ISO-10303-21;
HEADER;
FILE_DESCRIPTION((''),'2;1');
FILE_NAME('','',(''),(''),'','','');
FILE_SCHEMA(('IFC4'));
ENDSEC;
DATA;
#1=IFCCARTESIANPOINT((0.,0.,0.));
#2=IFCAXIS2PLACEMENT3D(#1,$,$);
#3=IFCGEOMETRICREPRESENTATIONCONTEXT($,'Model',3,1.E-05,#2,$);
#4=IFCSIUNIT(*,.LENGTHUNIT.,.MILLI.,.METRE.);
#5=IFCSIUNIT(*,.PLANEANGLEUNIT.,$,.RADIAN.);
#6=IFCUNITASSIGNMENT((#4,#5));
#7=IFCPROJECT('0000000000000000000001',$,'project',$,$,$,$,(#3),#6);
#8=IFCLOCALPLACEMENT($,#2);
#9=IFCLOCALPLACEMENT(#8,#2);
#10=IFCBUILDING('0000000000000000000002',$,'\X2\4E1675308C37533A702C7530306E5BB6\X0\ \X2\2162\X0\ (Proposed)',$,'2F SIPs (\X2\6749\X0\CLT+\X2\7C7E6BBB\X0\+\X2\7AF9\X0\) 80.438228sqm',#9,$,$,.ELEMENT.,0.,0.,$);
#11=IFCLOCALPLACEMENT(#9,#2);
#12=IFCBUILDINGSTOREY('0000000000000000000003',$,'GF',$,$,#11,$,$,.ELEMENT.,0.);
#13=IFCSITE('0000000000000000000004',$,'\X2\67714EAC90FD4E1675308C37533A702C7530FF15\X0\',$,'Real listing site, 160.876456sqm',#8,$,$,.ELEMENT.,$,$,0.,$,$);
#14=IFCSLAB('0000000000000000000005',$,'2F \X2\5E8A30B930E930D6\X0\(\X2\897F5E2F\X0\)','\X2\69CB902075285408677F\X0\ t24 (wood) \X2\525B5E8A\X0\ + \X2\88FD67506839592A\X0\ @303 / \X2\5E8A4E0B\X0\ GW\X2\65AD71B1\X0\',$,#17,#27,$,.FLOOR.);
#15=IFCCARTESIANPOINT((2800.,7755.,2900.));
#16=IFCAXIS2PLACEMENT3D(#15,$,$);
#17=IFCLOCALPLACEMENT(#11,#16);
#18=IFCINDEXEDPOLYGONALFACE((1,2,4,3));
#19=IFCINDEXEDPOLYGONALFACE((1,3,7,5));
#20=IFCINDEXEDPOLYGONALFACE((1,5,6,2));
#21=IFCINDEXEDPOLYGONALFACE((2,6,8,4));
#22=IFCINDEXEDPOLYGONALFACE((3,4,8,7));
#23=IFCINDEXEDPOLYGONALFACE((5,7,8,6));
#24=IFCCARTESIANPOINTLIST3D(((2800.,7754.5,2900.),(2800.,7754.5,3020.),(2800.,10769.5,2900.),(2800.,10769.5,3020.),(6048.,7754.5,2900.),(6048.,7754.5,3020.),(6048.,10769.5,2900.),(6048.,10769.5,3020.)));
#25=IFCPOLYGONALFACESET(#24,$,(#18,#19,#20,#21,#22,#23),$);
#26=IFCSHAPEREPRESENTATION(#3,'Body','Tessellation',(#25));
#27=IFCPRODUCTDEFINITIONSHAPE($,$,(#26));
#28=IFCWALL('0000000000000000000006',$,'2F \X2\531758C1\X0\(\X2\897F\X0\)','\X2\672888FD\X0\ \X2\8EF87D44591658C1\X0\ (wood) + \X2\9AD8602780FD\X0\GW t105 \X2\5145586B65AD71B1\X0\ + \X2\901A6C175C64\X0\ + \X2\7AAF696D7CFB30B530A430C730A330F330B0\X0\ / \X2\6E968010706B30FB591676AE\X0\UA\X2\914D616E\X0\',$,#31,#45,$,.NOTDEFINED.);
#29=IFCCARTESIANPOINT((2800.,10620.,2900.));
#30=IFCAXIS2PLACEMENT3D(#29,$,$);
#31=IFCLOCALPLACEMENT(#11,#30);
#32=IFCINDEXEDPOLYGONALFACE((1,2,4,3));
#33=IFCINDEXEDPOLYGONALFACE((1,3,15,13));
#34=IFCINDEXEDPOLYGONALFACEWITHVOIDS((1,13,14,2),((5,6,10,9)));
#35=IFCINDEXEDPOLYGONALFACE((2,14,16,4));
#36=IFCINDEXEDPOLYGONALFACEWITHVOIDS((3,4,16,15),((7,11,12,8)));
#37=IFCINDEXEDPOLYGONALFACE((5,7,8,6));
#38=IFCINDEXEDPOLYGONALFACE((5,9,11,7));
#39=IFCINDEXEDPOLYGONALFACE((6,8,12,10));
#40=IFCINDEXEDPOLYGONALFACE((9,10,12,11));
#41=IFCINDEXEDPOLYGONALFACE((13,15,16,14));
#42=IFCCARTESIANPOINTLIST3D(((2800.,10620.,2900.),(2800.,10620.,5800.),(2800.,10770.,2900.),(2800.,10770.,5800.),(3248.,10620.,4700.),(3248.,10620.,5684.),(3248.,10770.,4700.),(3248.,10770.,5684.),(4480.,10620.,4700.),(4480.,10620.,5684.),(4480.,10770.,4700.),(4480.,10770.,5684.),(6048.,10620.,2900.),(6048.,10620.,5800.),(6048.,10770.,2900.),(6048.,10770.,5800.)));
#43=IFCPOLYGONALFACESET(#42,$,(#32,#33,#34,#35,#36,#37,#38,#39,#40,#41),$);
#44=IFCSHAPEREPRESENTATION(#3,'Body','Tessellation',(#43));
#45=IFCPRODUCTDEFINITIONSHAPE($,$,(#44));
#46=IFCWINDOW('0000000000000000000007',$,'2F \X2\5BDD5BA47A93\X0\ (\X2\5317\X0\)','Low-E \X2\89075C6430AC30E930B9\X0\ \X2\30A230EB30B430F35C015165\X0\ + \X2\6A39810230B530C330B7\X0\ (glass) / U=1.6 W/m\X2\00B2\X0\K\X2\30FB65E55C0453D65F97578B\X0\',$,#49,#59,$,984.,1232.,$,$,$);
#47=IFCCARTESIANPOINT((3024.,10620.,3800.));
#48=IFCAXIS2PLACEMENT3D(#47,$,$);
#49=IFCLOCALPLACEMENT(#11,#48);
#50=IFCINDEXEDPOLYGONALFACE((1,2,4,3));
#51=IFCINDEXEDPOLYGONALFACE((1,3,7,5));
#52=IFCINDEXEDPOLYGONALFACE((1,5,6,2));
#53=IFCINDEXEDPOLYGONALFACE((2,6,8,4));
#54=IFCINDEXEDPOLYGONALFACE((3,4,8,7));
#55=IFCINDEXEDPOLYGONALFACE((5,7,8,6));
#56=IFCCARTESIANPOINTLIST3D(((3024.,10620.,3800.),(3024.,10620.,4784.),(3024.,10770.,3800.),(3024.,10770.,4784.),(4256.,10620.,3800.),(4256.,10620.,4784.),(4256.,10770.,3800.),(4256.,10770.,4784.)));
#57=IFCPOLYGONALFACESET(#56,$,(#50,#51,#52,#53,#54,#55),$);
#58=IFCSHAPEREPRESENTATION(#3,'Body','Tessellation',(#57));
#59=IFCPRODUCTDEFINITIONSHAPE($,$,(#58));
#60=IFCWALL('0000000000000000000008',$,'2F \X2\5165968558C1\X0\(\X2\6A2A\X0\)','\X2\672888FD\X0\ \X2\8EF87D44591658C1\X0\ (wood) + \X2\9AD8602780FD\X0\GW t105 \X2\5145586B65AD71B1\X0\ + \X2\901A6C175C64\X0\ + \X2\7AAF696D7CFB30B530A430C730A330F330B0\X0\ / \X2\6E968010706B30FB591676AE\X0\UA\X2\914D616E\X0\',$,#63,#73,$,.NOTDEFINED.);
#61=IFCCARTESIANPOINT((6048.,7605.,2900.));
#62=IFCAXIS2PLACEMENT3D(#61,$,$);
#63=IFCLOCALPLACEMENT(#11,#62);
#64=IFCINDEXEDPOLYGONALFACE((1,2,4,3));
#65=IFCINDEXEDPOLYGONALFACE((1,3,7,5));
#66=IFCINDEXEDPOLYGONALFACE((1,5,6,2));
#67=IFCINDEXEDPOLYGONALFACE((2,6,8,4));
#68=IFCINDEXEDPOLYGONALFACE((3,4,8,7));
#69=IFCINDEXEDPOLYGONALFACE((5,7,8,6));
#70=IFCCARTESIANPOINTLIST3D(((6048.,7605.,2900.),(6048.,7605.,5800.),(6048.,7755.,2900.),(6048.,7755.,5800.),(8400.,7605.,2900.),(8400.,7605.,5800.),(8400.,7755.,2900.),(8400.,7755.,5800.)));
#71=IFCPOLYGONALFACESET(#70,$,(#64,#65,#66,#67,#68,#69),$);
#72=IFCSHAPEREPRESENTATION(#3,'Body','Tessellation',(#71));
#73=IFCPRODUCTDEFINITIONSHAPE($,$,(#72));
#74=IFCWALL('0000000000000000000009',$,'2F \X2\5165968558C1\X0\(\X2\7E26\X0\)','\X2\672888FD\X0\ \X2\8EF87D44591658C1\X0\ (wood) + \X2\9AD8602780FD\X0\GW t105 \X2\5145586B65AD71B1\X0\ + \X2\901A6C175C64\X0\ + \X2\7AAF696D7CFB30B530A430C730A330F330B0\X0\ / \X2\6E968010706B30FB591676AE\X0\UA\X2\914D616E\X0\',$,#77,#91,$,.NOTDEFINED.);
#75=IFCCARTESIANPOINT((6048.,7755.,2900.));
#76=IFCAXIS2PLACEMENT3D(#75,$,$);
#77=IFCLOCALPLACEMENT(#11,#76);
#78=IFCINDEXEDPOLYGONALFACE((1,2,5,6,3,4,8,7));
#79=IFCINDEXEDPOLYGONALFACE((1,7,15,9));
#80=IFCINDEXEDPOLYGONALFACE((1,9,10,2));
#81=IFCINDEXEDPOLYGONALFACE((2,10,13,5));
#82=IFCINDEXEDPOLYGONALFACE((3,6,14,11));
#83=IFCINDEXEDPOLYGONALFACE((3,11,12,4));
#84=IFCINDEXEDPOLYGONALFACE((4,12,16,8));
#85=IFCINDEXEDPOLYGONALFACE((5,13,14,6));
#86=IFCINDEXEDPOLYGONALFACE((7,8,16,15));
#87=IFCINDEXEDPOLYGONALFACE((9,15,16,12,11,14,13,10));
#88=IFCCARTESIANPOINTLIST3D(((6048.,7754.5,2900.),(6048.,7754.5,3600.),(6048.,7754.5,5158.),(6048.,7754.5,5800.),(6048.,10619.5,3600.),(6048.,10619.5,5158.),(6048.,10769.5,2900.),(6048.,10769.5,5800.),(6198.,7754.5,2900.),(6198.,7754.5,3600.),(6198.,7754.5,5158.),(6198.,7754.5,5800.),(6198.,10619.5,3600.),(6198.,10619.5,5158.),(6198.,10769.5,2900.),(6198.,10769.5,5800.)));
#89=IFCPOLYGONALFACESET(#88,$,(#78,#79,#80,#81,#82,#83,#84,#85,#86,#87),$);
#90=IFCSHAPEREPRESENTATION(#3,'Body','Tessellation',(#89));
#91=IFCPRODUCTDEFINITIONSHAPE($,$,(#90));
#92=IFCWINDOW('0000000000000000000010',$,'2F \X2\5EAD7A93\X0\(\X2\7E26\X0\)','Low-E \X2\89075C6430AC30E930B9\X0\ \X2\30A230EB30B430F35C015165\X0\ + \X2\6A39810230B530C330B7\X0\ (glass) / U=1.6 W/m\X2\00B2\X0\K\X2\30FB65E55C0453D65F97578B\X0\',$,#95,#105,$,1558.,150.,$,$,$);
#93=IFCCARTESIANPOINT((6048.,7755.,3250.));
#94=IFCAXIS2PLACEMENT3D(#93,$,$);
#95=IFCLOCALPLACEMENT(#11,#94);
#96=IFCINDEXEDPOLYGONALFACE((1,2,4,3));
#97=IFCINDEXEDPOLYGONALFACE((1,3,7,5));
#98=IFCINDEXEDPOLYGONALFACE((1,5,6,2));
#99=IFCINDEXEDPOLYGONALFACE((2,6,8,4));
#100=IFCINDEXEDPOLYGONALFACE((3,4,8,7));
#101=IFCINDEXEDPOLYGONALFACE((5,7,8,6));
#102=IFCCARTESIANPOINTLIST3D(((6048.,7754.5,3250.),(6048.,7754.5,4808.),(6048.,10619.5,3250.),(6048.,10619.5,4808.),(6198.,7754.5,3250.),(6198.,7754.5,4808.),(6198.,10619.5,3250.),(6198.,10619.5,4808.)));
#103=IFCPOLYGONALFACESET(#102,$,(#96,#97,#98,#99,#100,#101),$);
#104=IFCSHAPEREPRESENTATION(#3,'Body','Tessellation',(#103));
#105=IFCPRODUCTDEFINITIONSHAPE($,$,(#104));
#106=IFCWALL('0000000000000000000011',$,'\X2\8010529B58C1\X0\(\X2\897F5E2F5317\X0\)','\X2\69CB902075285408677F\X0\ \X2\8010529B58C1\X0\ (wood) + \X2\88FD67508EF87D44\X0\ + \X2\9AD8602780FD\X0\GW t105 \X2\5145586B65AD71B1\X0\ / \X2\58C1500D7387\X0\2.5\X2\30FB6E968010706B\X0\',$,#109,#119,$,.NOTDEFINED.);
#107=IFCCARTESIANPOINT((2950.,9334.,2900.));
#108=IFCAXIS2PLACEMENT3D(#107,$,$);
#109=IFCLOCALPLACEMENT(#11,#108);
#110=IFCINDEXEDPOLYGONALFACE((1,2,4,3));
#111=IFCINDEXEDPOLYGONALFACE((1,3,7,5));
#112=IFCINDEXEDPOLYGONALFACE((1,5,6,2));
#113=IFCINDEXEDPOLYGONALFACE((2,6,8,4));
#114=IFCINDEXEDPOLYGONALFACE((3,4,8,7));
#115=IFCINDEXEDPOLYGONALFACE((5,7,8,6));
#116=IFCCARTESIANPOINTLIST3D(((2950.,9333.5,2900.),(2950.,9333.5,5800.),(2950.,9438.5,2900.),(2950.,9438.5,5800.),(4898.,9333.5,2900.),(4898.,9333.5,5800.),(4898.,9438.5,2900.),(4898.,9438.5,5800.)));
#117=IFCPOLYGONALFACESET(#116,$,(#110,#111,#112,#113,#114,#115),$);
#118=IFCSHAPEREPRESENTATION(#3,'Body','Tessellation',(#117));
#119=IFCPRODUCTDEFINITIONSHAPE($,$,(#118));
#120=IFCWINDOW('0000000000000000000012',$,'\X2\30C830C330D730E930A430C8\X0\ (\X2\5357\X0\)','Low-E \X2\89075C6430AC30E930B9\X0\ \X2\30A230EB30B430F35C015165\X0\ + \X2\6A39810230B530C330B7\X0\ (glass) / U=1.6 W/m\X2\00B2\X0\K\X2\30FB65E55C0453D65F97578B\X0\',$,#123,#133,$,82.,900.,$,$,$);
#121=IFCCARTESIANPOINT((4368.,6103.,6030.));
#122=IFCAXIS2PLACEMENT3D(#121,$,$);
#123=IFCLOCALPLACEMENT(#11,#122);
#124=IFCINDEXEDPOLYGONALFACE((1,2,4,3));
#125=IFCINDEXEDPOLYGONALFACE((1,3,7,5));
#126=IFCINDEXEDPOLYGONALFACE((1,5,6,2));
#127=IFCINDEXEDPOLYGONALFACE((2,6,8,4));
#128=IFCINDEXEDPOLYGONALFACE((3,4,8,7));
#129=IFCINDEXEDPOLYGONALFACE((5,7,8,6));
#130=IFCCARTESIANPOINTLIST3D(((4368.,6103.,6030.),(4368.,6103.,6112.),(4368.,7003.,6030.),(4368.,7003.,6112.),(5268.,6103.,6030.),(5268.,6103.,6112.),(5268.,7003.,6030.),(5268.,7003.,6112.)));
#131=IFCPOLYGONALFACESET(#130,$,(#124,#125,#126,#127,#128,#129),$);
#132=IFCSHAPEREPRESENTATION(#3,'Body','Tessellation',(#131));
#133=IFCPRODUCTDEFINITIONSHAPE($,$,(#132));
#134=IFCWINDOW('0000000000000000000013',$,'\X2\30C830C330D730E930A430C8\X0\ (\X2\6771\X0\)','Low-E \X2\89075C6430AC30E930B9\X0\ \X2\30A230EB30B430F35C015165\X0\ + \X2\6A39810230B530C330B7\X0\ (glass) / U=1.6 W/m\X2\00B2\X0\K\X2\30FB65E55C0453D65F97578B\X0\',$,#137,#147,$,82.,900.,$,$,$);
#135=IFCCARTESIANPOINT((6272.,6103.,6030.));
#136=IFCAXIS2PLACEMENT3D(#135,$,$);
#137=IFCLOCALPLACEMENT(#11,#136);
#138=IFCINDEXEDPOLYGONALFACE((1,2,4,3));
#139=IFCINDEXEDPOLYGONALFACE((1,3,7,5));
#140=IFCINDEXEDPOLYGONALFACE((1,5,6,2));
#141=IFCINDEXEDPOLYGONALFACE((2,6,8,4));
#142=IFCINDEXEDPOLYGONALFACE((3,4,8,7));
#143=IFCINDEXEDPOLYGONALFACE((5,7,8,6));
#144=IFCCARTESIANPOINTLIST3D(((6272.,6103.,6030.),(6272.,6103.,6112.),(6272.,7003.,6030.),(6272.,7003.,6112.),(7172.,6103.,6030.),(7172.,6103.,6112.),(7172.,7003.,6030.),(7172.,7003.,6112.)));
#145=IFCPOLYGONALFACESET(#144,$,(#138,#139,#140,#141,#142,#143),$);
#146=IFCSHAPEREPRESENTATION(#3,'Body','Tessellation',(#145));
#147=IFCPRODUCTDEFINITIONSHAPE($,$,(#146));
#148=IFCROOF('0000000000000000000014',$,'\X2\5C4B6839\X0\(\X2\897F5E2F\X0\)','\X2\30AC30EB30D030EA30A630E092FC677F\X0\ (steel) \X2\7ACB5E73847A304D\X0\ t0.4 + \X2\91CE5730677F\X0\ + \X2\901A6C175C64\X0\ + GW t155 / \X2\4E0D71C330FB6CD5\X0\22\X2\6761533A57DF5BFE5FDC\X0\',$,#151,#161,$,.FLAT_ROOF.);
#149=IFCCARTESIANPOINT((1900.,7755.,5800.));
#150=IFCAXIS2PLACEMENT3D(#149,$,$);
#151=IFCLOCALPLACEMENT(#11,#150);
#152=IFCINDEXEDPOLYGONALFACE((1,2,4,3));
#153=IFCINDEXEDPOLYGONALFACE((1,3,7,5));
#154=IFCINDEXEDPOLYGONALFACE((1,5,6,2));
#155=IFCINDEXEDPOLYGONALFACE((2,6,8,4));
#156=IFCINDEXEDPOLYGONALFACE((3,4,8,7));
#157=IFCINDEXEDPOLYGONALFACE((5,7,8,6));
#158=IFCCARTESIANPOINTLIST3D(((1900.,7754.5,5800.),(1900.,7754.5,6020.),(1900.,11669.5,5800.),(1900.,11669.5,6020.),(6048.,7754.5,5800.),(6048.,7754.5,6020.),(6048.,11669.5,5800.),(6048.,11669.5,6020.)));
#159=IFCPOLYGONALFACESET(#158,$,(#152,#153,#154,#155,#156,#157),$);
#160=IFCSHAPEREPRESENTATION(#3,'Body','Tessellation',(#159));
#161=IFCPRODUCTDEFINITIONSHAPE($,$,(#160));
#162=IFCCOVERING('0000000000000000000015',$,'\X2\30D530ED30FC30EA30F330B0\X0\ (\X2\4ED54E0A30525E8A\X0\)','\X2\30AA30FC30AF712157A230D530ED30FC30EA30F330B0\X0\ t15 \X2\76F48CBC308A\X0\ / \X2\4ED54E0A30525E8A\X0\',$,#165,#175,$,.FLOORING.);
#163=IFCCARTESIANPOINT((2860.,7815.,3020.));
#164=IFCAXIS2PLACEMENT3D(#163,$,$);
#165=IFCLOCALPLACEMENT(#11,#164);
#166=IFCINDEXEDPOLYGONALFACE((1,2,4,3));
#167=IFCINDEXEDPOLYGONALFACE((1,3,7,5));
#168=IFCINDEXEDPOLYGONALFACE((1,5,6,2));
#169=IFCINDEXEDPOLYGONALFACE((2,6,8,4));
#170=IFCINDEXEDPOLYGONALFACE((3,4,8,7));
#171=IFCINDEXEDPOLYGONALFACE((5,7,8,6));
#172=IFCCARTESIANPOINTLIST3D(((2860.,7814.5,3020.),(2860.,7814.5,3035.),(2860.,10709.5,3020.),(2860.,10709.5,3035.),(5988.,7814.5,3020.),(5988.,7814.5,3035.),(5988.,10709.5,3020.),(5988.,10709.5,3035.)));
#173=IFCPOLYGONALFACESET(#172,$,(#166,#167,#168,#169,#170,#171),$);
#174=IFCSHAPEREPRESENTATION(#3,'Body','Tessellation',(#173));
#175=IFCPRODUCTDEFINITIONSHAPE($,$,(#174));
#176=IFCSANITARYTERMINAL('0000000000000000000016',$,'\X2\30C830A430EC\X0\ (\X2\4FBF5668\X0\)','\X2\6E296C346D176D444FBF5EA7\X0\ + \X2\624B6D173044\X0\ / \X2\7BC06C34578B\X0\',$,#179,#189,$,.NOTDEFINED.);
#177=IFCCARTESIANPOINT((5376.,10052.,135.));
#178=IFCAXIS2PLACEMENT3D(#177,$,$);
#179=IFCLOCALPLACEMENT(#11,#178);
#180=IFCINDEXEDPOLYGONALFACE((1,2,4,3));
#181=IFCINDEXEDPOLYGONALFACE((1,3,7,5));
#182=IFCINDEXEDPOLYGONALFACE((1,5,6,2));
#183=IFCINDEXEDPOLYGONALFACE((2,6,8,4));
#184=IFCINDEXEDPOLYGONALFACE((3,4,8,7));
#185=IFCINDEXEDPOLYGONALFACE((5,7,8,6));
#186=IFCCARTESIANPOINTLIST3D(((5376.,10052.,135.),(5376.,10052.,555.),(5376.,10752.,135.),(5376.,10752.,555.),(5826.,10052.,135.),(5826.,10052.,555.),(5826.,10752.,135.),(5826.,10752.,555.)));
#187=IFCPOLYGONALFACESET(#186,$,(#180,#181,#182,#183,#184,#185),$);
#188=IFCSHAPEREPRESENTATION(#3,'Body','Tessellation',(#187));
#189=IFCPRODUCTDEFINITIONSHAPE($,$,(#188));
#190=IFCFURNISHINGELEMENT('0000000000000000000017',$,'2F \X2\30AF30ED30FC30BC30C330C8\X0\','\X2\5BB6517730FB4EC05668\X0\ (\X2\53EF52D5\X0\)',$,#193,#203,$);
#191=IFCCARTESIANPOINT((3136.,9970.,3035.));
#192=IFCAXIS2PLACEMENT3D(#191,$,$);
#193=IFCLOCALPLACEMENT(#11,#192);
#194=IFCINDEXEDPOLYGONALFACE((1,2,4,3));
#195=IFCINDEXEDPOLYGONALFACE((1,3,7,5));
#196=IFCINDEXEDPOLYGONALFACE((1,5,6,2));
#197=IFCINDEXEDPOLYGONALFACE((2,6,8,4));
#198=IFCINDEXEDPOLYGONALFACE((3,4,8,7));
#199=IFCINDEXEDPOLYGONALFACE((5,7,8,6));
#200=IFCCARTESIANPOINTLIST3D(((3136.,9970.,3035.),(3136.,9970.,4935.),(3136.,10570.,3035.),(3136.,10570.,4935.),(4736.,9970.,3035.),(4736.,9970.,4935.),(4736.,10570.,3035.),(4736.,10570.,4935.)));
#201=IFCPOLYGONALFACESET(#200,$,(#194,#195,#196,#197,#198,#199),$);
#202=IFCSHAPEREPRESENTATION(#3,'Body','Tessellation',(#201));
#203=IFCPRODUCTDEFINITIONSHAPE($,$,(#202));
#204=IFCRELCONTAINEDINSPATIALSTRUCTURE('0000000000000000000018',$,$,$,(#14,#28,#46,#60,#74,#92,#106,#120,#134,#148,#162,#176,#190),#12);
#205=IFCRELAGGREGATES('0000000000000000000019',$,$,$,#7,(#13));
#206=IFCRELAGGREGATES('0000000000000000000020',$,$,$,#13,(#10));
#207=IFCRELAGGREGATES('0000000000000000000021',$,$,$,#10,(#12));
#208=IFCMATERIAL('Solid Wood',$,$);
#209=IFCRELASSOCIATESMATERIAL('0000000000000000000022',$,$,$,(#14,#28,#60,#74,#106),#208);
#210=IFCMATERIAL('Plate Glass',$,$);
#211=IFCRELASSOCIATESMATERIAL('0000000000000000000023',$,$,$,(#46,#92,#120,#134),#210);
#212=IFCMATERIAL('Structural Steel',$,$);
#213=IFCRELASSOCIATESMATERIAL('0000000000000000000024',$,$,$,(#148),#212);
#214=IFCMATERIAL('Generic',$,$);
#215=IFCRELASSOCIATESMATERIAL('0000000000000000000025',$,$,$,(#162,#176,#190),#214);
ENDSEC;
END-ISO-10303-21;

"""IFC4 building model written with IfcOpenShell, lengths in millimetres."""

from ifc_helpers import new_model, si_unit, frame, frame_2d, origin, place, context, project, spatial, rectangle, extrude, material, element, fill, save


model = new_model("IFC4")

# Units and contexts
model_context = context("Model", 3, precision=1e-05, world=origin())
ifc_project = project(units=[si_unit("LENGTHUNIT", "METRE", prefix="MILLI"), si_unit("PLANEANGLEUNIT", "RADIAN")], contexts=[model_context])

# Site, building, storey
site_placement = place(None, origin())
site = spatial("IfcSite", under=ifc_project, at=site_placement, Name="東京都世田谷区瀬田５", ObjectType="Real listing site, 160.876456sqm", CompositionType="ELEMENT", RefElevation=0.0)
building_placement = place(site_placement, origin())
building = spatial("IfcBuilding", under=site, at=building_placement, Name="世田谷区瀬田の家 Ⅲ (Proposed)", ObjectType="2F SIPs (杉CLT+籾殻+竹) 80.438228sqm", CompositionType="ELEMENT", ElevationOfRefHeight=0.0, ElevationOfTerrain=0.0)
storey_placement = place(building_placement, origin())
storey = spatial("IfcBuildingStorey", under=building, at=storey_placement, Name="GF", CompositionType="ELEMENT", Elevation=0.0)

# Slab
ifc_material_1 = material(Name="Solid Wood")
slab_placement = place(storey_placement, frame((2800.0, 7755.0, 2900.0)))
element("IfcSlab", 1, at=slab_placement, inside=storey, material=ifc_material_1, Name="2F 床スラブ(西帯)", Description="構造用合板 t24 (wood) 剛床 + 製材根太 @303 / 床下 GW断熱", PredefinedType="FLOOR", context=model_context, shape_type="SweptSolid", body=[
    extrude(rectangle(XDim=3248.0, YDim=3015.0, at=frame_2d((1624.0, 1507.0))), frame((2800.0, 7755.0, 2900.0)), (0.0, 0.0, 1.0), 120.0),
])

# Wall, opening, window
wall_1_placement = place(storey_placement, frame((2800.0, 10620.0, 2900.0)))
wall_1 = element("IfcWall", 2, at=wall_1_placement, inside=storey, material=ifc_material_1, Name="2F 北壁(西)", Description="木製 軸組外壁 (wood) + 高性能GW t105 充填断熱 + 通気層 + 窯業系サイディング / 準耐火・外皮UA配慮", PredefinedType="NOTDEFINED", context=model_context, shape_type="SweptSolid", body=[
    extrude(rectangle(XDim=3248.0, YDim=150.0, at=frame_2d((1624.0, 75.0))), frame((2800.0, 10620.0, 2900.0)), (0.0, 0.0, 1.0), 2900.0),
])
opening_1_placement = place(storey_placement, frame((3024.0, 10620.0, 3800.0)))
opening_1 = element("IfcOpeningElement", 3, at=opening_1_placement, cuts=wall_1, PredefinedType="NOTDEFINED", context=model_context, shape_type="SweptSolid", body=[
    extrude(rectangle(XDim=1232.0, YDim=150.0, at=frame_2d((616.0, 75.0))), frame((3024.0, 10620.0, 3800.0)), (0.0, 0.0, 1.0), 984.0),
])
ifc_material_2 = material(Name="Plate Glass")
window_1_placement = place(storey_placement, frame((3024.0, 10620.0, 3800.0)))
window_1 = element("IfcWindow", 4, at=window_1_placement, inside=storey, material=ifc_material_2, Name="2F 寝室窓 (北)", Description="Low-E 複層ガラス アルゴン封入 + 樹脂サッシ (glass) / U=1.6 W/m²K・日射取得型", OverallHeight=984.0, OverallWidth=1232.0, context=model_context, shape_type="SweptSolid", body=[
    extrude(rectangle(XDim=1232.0, YDim=150.0, at=frame_2d((616.0, 75.0))), frame((3024.0, 10620.0, 3800.0)), (0.0, 0.0, 1.0), 984.0),
])
fill(opening_1, window_1)

# Wall
wall_2_placement = place(storey_placement, frame((6048.0, 7605.0, 2900.0)))
element("IfcWall", 5, at=wall_2_placement, inside=storey, material=ifc_material_1, Name="2F 入隅壁(横)", Description="木製 軸組外壁 (wood) + 高性能GW t105 充填断熱 + 通気層 + 窯業系サイディング / 準耐火・外皮UA配慮", PredefinedType="NOTDEFINED", context=model_context, shape_type="SweptSolid", body=[
    extrude(rectangle(XDim=2352.0, YDim=150.0, at=frame_2d((1176.0, 75.0))), frame((6048.0, 7605.0, 2900.0)), (0.0, 0.0, 1.0), 2900.0),
])

# Wall, opening, window
wall_3_placement = place(storey_placement, frame((6048.0, 7755.0, 2900.0)))
wall_3 = element("IfcWall", 6, at=wall_3_placement, inside=storey, material=ifc_material_1, Name="2F 入隅壁(縦)", Description="木製 軸組外壁 (wood) + 高性能GW t105 充填断熱 + 通気層 + 窯業系サイディング / 準耐火・外皮UA配慮", PredefinedType="NOTDEFINED", context=model_context, shape_type="SweptSolid", body=[
    extrude(rectangle(XDim=150.0, YDim=3015.0, at=frame_2d((75.0, 1507.0))), frame((6048.0, 7755.0, 2900.0)), (0.0, 0.0, 1.0), 2900.0),
])
opening_2_placement = place(storey_placement, frame((6048.0, 7755.0, 3250.0)))
opening_2 = element("IfcOpeningElement", 7, at=opening_2_placement, cuts=wall_3, PredefinedType="NOTDEFINED", context=model_context, shape_type="SweptSolid", body=[
    extrude(rectangle(XDim=150.0, YDim=2865.0, at=frame_2d((75.0, 1432.0))), frame((6048.0, 7755.0, 3250.0)), (0.0, 0.0, 1.0), 1558.0),
])
window_2_placement = place(storey_placement, frame((6048.0, 7755.0, 3250.0)))
window_2 = element("IfcWindow", 8, at=window_2_placement, inside=storey, material=ifc_material_2, Name="2F 庭窓(縦)", Description="Low-E 複層ガラス アルゴン封入 + 樹脂サッシ (glass) / U=1.6 W/m²K・日射取得型", OverallHeight=1558.0, OverallWidth=150.0, context=model_context, shape_type="SweptSolid", body=[
    extrude(rectangle(XDim=150.0, YDim=2865.0, at=frame_2d((75.0, 1432.0))), frame((6048.0, 7755.0, 3250.0)), (0.0, 0.0, 1.0), 1558.0),
])
fill(opening_2, window_2)

# Wall
wall_4_placement = place(storey_placement, frame((2950.0, 9334.0, 2900.0)))
element("IfcWall", 9, at=wall_4_placement, inside=storey, material=ifc_material_1, Name="耐力壁(西帯北)", Description="構造用合板 耐力壁 (wood) + 製材軸組 + 高性能GW t105 充填断熱 / 壁倍率2.5・準耐火", PredefinedType="NOTDEFINED", context=model_context, shape_type="SweptSolid", body=[
    extrude(rectangle(XDim=1948.0, YDim=105.0, at=frame_2d((974.0, 52.0))), frame((2950.0, 9334.0, 2900.0)), (0.0, 0.0, 1.0), 2900.0),
])

# Windows
window_3_placement = place(storey_placement, frame((4368.0, 6103.0, 6030.0)))
element("IfcWindow", 10, at=window_3_placement, inside=storey, material=ifc_material_2, Name="トップライト (南)", Description="Low-E 複層ガラス アルゴン封入 + 樹脂サッシ (glass) / U=1.6 W/m²K・日射取得型", OverallHeight=82.0, OverallWidth=900.0, context=model_context, shape_type="SweptSolid", body=[
    extrude(rectangle(XDim=900.0, YDim=900.0, at=frame_2d((450.0, 450.0))), frame((4368.0, 6103.0, 6030.0)), (0.0, 0.0, 1.0), 82.0),
])
window_4_placement = place(storey_placement, frame((6272.0, 6103.0, 6030.0)))
element("IfcWindow", 11, at=window_4_placement, inside=storey, material=ifc_material_2, Name="トップライト (東)", Description="Low-E 複層ガラス アルゴン封入 + 樹脂サッシ (glass) / U=1.6 W/m²K・日射取得型", OverallHeight=82.0, OverallWidth=900.0, context=model_context, shape_type="SweptSolid", body=[
    extrude(rectangle(XDim=900.0, YDim=900.0, at=frame_2d((450.0, 450.0))), frame((6272.0, 6103.0, 6030.0)), (0.0, 0.0, 1.0), 82.0),
])

# Roof
ifc_material_3 = material(Name="Structural Steel")
for number, where, name in (
    (12, (1900.0, 7755.0, 5800.0), "屋根(西帯)"),
):
    element("IfcRoof", number, at=place(storey_placement, frame(where)), inside=storey, material=ifc_material_3, Name=name, Description="ガルバリウム鋼板 (steel) 立平葺き t0.4 + 野地板 + 通気層 + GW t155 / 不燃・法22条区域対応", PredefinedType="FLAT_ROOF", context=model_context, shape_type="SweptSolid", body=[
        extrude(rectangle(XDim=4148.0, YDim=3915.0, at=frame_2d((2074.0, 1957.0))), frame((1900.0, 7755.0, 5800.0)), (0.0, 0.0, 1.0), 220.0),
    ])

# Covering
ifc_material_4 = material(Name="Generic")
covering_placement = place(storey_placement, frame((2860.0, 7815.0, 3020.0)))
element("IfcCovering", 13, at=covering_placement, inside=storey, material=ifc_material_4, Name="フローリング (仕上げ床)", Description="オーク無垢フローリング t15 直貼り / 仕上げ床", PredefinedType="FLOORING", context=model_context, shape_type="SweptSolid", body=[
    extrude(rectangle(XDim=3128.0, YDim=2895.0, at=frame_2d((1564.0, 1447.0))), frame((2860.0, 7815.0, 3020.0)), (0.0, 0.0, 1.0), 15.0),
])

# Sanitary terminal
sanitary_terminal_placement = place(storey_placement, frame((5376.0, 10052.0, 135.0)))
element("IfcSanitaryTerminal", 14, at=sanitary_terminal_placement, inside=storey, material=ifc_material_4, Name="トイレ (便器)", Description="温水洗浄便座 + 手洗い / 節水型", PredefinedType="NOTDEFINED", context=model_context, shape_type="SweptSolid", body=[
    extrude(rectangle(XDim=450.0, YDim=700.0, at=frame_2d((225.0, 350.0))), frame((5376.0, 10052.0, 135.0)), (0.0, 0.0, 1.0), 420.0),
])

# Furnishing element
furnishing_1_placement = place(storey_placement, frame((3136.0, 9970.0, 3035.0)))
element("IfcFurnishingElement", 15, at=furnishing_1_placement, inside=storey, material=ifc_material_4, Name="2F クローゼット", Description="家具・什器 (可動)", context=model_context, shape_type="SweptSolid", body=[
    extrude(rectangle(XDim=1600.0, YDim=600.0, at=frame_2d((800.0, 300.0))), frame((3136.0, 9970.0, 3035.0)), (0.0, 0.0, 1.0), 1900.0),
])

save(model, "model.ifc")
